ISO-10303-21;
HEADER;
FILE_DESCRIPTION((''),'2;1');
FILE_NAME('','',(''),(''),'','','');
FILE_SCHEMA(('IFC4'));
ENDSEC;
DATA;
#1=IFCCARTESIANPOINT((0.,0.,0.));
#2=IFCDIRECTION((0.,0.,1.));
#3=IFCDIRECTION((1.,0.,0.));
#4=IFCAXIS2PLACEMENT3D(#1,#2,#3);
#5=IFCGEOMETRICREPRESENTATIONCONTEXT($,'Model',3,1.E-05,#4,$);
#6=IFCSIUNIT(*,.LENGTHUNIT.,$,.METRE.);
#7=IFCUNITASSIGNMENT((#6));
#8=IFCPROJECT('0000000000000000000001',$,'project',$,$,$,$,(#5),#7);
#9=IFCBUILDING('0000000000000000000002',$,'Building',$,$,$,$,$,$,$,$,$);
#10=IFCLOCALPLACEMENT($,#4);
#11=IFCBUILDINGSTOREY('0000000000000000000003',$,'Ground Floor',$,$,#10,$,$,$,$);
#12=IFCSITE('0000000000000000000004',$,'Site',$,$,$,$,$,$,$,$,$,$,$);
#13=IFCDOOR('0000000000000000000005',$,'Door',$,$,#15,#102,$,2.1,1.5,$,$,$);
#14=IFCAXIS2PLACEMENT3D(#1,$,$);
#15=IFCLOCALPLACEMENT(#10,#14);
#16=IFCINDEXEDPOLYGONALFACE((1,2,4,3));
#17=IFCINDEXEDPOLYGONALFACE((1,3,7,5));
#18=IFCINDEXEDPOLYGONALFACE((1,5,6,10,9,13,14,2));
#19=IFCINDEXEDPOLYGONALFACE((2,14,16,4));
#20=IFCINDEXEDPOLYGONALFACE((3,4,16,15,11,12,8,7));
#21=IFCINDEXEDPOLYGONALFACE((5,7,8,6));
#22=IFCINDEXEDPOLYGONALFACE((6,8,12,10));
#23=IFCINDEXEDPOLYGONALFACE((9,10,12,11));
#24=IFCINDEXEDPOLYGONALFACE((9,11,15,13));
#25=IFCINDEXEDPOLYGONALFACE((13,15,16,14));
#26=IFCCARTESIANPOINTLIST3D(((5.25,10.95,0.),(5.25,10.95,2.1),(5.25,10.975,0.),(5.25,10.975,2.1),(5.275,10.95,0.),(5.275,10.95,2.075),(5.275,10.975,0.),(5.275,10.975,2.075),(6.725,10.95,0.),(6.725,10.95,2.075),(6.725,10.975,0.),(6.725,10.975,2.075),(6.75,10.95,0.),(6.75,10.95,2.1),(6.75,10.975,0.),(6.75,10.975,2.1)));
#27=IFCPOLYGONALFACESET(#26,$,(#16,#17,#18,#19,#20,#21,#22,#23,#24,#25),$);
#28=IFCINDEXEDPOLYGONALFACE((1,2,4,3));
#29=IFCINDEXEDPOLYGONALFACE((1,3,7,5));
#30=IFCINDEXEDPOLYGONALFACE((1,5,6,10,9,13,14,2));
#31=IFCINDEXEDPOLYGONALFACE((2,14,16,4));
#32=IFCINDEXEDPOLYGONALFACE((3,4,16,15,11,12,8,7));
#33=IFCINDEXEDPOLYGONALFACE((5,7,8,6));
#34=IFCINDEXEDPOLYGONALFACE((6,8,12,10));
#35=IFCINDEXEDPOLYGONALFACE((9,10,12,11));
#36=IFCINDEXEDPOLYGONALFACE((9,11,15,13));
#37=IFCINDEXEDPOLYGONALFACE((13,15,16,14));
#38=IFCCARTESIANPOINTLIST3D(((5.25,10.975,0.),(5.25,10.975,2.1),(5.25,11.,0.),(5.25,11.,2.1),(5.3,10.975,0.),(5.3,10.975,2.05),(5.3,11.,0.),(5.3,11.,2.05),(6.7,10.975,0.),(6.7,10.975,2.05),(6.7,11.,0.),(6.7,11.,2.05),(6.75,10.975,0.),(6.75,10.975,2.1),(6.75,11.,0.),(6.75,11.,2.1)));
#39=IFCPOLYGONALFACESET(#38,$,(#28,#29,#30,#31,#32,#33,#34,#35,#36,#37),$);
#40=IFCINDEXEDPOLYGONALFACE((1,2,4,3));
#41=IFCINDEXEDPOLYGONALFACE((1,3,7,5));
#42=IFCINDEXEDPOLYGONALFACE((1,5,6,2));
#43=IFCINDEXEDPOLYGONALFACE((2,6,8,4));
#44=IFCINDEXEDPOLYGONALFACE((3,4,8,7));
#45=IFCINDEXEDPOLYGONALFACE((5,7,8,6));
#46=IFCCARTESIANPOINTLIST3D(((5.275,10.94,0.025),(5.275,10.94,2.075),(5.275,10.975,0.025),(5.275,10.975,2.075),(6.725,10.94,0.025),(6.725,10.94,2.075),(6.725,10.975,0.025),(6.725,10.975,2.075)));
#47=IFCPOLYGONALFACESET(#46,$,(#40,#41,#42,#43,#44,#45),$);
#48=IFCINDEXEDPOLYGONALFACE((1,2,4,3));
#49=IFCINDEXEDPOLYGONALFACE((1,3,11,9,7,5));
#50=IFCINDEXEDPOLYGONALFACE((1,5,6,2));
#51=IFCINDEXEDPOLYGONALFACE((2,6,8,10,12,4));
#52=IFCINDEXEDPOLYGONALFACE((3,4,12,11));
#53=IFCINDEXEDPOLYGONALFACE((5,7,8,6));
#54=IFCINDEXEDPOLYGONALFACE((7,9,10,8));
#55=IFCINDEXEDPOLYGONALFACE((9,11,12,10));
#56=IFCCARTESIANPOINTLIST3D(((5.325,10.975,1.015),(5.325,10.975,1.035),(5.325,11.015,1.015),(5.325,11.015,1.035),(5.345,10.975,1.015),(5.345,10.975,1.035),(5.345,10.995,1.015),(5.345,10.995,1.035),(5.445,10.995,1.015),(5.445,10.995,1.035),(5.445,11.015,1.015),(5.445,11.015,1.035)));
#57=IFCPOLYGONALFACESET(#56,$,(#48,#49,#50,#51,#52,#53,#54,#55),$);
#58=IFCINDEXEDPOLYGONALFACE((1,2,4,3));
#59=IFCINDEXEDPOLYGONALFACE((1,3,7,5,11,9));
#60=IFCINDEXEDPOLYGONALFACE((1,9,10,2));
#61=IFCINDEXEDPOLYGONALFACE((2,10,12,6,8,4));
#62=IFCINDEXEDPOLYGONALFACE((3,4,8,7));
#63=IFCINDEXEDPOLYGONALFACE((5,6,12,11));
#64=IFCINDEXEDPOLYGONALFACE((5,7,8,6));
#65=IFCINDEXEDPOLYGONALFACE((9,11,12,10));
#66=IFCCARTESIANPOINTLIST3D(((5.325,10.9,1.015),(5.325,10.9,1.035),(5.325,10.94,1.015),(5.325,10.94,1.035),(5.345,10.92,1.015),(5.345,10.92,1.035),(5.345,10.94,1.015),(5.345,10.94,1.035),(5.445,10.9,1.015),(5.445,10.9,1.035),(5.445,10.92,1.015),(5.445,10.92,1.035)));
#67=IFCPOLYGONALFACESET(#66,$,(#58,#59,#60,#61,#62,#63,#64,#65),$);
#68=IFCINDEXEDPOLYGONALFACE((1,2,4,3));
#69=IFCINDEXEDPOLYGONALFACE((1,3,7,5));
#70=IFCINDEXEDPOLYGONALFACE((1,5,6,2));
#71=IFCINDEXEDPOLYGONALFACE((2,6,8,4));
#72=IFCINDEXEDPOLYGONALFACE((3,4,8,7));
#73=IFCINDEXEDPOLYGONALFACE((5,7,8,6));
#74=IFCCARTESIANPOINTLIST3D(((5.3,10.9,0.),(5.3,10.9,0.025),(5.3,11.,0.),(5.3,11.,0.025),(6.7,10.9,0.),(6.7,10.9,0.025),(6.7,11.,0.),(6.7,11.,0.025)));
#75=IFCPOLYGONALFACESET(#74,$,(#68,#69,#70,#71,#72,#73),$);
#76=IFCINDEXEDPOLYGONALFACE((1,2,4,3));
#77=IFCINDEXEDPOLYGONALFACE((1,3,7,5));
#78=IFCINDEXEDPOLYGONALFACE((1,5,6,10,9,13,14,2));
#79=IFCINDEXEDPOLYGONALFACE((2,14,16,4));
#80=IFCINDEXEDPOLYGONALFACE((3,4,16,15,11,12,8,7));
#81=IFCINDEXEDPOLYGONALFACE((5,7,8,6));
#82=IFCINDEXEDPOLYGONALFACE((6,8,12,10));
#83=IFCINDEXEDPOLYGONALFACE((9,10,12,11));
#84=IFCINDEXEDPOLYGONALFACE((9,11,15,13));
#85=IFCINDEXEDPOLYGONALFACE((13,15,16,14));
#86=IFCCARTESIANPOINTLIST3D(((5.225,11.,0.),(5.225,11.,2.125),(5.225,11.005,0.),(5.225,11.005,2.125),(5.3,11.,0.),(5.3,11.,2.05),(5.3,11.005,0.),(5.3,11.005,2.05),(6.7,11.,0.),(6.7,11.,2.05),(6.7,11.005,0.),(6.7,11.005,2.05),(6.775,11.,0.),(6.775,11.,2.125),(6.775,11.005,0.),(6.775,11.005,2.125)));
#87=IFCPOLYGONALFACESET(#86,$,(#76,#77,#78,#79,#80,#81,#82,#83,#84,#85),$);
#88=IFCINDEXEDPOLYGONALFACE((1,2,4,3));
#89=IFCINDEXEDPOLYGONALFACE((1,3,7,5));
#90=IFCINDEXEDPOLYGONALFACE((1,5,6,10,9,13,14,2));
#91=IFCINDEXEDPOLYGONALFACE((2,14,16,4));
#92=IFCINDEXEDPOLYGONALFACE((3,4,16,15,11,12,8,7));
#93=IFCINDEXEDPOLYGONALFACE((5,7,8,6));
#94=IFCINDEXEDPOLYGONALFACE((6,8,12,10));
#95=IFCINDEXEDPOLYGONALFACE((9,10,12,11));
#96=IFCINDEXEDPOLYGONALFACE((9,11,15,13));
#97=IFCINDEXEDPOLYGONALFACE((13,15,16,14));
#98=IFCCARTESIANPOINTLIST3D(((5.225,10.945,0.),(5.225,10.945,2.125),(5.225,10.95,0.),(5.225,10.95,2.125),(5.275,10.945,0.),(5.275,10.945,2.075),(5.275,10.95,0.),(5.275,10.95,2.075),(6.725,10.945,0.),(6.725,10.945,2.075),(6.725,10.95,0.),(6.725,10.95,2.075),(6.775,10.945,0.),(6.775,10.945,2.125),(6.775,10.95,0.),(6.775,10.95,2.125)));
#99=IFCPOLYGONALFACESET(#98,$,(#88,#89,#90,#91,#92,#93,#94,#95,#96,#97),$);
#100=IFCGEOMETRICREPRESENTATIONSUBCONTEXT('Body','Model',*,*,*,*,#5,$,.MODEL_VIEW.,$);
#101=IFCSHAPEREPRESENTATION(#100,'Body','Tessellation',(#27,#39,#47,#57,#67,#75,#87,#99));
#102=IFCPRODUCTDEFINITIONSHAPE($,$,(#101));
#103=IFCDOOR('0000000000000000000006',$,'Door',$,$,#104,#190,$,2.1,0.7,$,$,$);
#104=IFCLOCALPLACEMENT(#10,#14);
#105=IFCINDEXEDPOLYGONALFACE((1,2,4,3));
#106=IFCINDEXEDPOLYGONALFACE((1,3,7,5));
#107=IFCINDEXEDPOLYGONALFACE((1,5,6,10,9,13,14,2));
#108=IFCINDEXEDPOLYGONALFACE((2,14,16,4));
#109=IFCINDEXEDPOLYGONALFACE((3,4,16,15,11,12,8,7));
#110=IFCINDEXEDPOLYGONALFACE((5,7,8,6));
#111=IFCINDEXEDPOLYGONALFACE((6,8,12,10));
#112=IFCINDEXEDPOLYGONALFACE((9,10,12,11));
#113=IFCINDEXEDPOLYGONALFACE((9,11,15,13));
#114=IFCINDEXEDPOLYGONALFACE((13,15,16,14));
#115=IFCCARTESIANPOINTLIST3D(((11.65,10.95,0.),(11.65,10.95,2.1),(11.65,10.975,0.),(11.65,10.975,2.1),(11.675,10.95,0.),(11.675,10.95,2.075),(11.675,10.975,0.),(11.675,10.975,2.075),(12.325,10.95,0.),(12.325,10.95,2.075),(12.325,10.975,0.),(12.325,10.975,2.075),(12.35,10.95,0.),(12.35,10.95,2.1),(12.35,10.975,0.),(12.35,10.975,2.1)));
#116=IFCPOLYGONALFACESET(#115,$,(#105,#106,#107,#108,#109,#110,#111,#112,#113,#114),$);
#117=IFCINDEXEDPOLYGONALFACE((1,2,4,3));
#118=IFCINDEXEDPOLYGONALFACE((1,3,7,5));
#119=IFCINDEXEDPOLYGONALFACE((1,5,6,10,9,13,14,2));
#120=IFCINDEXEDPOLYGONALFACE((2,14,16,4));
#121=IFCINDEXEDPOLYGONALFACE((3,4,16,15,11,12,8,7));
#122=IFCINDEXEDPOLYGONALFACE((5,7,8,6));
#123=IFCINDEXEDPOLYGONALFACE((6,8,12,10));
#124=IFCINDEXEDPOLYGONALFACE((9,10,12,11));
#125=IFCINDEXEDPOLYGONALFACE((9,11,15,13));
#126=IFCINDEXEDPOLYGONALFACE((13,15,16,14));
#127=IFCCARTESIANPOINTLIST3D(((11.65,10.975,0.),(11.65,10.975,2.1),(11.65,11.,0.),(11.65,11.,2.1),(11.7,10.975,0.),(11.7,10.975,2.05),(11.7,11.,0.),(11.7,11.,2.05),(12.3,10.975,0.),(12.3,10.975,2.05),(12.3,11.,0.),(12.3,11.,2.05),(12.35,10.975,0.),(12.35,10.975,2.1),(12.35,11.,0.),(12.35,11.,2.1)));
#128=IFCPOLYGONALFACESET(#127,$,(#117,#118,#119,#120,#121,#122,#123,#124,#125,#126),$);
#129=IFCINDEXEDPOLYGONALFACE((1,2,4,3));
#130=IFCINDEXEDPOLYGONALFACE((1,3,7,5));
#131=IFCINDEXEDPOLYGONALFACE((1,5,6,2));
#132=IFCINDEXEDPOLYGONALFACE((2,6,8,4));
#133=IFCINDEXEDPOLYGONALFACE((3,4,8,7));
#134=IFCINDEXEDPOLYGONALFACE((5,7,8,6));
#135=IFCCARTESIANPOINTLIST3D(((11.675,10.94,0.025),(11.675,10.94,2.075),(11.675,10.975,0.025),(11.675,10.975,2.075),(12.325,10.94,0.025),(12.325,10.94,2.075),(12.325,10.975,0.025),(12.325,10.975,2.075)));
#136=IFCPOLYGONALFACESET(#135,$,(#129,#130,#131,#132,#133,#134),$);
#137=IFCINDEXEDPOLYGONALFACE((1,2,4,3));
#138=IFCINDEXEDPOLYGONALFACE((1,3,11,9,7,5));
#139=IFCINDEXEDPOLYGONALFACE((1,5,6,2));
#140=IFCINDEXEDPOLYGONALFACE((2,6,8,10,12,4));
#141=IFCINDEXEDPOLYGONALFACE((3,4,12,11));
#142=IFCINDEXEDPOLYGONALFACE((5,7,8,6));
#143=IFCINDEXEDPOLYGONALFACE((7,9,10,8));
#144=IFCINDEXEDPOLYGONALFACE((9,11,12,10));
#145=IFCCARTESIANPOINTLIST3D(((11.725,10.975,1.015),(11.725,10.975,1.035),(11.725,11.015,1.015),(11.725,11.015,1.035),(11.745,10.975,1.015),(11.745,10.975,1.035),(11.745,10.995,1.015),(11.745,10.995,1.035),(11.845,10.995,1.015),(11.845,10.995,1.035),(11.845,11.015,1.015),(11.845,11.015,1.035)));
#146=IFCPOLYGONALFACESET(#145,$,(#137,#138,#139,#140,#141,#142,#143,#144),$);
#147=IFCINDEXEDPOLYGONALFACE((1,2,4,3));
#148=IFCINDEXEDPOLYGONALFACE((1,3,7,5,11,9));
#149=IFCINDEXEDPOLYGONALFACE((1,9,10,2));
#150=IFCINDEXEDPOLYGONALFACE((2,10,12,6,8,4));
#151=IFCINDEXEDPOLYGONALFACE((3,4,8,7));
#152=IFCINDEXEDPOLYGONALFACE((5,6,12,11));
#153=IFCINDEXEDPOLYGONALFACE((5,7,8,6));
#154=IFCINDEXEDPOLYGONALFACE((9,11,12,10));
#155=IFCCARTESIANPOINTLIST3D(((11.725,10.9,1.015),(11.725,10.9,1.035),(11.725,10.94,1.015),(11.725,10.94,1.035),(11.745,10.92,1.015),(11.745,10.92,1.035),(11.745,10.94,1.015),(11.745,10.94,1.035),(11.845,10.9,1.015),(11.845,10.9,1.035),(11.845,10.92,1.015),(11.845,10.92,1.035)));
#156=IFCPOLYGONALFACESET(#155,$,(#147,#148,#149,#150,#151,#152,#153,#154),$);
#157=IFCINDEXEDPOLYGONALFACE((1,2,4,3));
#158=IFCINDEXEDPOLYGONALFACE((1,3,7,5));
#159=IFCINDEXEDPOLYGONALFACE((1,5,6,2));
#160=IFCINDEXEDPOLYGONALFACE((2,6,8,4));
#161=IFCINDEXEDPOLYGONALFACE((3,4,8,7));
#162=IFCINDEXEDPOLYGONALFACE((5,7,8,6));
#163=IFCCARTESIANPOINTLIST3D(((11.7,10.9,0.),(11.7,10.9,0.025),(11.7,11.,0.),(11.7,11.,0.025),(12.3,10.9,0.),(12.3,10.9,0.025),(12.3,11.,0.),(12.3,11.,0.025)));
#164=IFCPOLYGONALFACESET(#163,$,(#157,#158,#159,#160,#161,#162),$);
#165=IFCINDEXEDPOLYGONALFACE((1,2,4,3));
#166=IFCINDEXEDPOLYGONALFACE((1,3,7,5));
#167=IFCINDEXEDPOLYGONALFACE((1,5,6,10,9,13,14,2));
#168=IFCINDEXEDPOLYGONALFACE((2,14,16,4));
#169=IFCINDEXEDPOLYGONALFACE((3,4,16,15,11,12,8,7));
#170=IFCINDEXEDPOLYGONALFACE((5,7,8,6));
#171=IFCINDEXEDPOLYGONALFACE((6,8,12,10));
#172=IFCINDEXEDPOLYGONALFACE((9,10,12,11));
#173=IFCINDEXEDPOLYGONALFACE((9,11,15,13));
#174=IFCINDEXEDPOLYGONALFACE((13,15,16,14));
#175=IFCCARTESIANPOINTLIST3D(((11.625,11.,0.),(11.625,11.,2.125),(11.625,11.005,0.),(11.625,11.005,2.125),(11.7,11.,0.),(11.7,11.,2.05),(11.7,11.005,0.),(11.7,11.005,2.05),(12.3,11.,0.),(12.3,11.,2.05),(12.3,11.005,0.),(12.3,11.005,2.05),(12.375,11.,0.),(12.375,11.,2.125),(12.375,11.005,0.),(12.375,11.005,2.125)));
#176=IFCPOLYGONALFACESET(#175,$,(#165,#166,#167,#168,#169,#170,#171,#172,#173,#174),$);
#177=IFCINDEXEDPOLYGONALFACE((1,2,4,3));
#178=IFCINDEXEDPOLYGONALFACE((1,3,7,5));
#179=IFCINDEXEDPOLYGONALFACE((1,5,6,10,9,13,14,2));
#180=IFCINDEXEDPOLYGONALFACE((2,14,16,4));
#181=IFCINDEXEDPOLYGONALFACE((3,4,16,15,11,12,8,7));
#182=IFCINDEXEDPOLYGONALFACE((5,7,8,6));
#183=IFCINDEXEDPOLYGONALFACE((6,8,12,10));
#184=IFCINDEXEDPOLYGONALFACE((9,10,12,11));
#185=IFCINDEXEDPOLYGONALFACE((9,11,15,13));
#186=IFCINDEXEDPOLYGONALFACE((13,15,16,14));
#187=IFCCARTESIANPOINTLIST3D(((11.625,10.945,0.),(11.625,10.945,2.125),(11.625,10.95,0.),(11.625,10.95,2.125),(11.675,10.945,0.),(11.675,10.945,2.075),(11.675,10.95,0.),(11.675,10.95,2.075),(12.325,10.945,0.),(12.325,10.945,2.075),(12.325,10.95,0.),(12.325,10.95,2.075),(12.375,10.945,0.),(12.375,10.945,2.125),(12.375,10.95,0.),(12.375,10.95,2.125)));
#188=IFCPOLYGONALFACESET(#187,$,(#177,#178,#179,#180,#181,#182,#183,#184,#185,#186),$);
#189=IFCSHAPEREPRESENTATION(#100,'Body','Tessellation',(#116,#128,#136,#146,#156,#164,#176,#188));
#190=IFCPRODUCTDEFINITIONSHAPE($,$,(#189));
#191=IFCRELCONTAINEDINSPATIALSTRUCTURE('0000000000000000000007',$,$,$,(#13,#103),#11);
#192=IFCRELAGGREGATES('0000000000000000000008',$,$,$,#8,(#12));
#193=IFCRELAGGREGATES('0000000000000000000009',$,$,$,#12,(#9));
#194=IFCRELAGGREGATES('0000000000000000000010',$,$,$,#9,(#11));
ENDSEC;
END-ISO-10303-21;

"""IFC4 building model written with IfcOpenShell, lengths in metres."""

from ifc_helpers import new_model, si_unit, frame, origin_with_axes, place, context, subcontext, project, spatial, line, indexed_curve, outline, extrude, element, save


model = new_model("IFC4")

# Units and contexts
model_context = context("Model", 3, precision=1e-05, world=origin_with_axes())
body_context = subcontext(model_context, "Body", "Model", "MODEL_VIEW")
ifc_project = project(units=[si_unit("LENGTHUNIT", "METRE")], contexts=[model_context])

# Site, building, storey
site = spatial("IfcSite", under=ifc_project, Name="Site")
building = spatial("IfcBuilding", under=site, Name="Building")
storey_placement = place(None, origin_with_axes())
storey = spatial("IfcBuildingStorey", under=building, at=storey_placement, Name="Ground Floor")

# Doors
door_1_placement = place(storey_placement, frame((6.75, 11.0, 0.0), z_axis=(0.0, 0.0, 1.0), x_axis=(-1.0, 0.0, 0.0)))
element("IfcDoor", 1, at=door_1_placement, inside=storey, Name="Door", OverallHeight=2.1, OverallWidth=1.5, context=body_context, shape_type="SweptSolid", body=[
    extrude(outline(indexed_curve([(0.0, 0.0), (0.0, 2.1), (1.5, 2.1), (1.5, 0.0), (1.475, 0.0), (1.475, 2.075), (0.025, 2.075), (0.025, 0.0)], segments=[line(1, 2, 3, 4, 5, 6, 7, 8, 1)])), frame((0.0, 0.025, 0.0), z_axis=(0.0, -1.0, 0.0), x_axis=(1.0, 0.0, 0.0)), (0.0, 0.0, -1.0), 0.025),
    extrude(outline(indexed_curve([(0.0, 0.0), (0.0, 2.1), (1.5, 2.1), (1.5, 0.0), (1.45, 0.0), (1.45, 2.05), (0.05, 2.05), (0.05, 0.0)], segments=[line(1, 2, 3, 4, 5, 6, 7, 8, 1)])), frame((0.0, 0.0, 0.0), z_axis=(0.0, -1.0, 0.0), x_axis=(1.0, 0.0, 0.0)), (0.0, 0.0, -1.0), 0.025),
    extrude(outline(indexed_curve([(0.0, 0.0), (1.45, 0.0), (1.45, 0.035), (0.0, 0.035)], segments=[line(1, 2, 3, 4, 1)])), frame((0.025, 0.025, 0.025), z_axis=(0.0, 0.0, 1.0), x_axis=(1.0, 0.0, 0.0)), (0.0, 0.0, 1.0), 2.05),
    extrude(outline(indexed_curve([(0.0, 0.0), (0.0, -0.04), (-0.12, -0.04), (-0.12, -0.02), (-0.02, -0.02), (-0.02, 0.0)], segments=[line(1, 2, 3, 4, 5, 6, 1)])), frame((1.425, 0.025, 1.015), z_axis=(0.0, 0.0, 1.0), x_axis=(1.0, 0.0, 0.0)), (0.0, 0.0, 1.0), 0.02),
    extrude(outline(indexed_curve([(0.0, 0.0), (0.0, 0.04), (-0.12, 0.04), (-0.12, 0.02), (-0.02, 0.02), (-0.02, 0.0)], segments=[line(1, 2, 3, 4, 5, 6, 1)])), frame((1.425, 0.06, 1.015), z_axis=(0.0, 0.0, 1.0), x_axis=(1.0, 0.0, 0.0)), (0.0, 0.0, 1.0), 0.02),
    extrude(outline(indexed_curve([(0.0, 0.0), (1.4, 0.0), (1.4, 0.1), (0.0, 0.1)], segments=[line(1, 2, 3, 4, 1)])), frame((0.05, 0.0, 0.0), z_axis=(0.0, 0.0, 1.0), x_axis=(1.0, 0.0, 0.0)), (0.0, 0.0, 1.0), 0.025),
    extrude(outline(indexed_curve([(0.0, 0.0), (0.0, 2.125), (1.55, 2.125), (1.55, 0.0), (1.475, 0.0), (1.475, 2.05), (0.075, 2.05), (0.075, 0.0)], segments=[line(1, 2, 3, 4, 5, 6, 7, 8, 1)])), frame((-0.025, -0.005, 0.0), z_axis=(0.0, -1.0, 0.0), x_axis=(1.0, 0.0, 0.0)), (0.0, 0.0, -1.0), 0.005),
    extrude(outline(indexed_curve([(0.0, 0.0), (0.0, 2.125), (1.55, 2.125), (1.55, 0.0), (1.5, 0.0), (1.5, 2.075), (0.05, 2.075), (0.05, 0.0)], segments=[line(1, 2, 3, 4, 5, 6, 7, 8, 1)])), frame((-0.025, 0.05, 0.0), z_axis=(0.0, -1.0, 0.0), x_axis=(1.0, 0.0, 0.0)), (0.0, 0.0, -1.0), 0.005),
])
door_2_placement = place(storey_placement, frame((12.35, 11.0, 0.0), z_axis=(0.0, 0.0, 1.0), x_axis=(-1.0, 0.0, 0.0)))
element("IfcDoor", 2, at=door_2_placement, inside=storey, Name="Door", OverallHeight=2.1, OverallWidth=0.7, context=body_context, shape_type="SweptSolid", body=[
    extrude(outline(indexed_curve([(0.0, 0.0), (0.0, 2.1), (0.7, 2.1), (0.7, 0.0), (0.675, 0.0), (0.675, 2.075), (0.025, 2.075), (0.025, 0.0)], segments=[line(1, 2, 3, 4, 5, 6, 7, 8, 1)])), frame((0.0, 0.025, 0.0), z_axis=(0.0, -1.0, 0.0), x_axis=(1.0, 0.0, 0.0)), (0.0, 0.0, -1.0), 0.025),
    extrude(outline(indexed_curve([(0.0, 0.0), (0.0, 2.1), (0.7, 2.1), (0.7, 0.0), (0.65, 0.0), (0.65, 2.05), (0.05, 2.05), (0.05, 0.0)], segments=[line(1, 2, 3, 4, 5, 6, 7, 8, 1)])), frame((0.0, 0.0, 0.0), z_axis=(0.0, -1.0, 0.0), x_axis=(1.0, 0.0, 0.0)), (0.0, 0.0, -1.0), 0.025),
    extrude(outline(indexed_curve([(0.0, 0.0), (0.65, 0.0), (0.65, 0.035), (0.0, 0.035)], segments=[line(1, 2, 3, 4, 1)])), frame((0.025, 0.025, 0.025), z_axis=(0.0, 0.0, 1.0), x_axis=(1.0, 0.0, 0.0)), (0.0, 0.0, 1.0), 2.05),
    extrude(outline(indexed_curve([(0.0, 0.0), (0.0, -0.04), (-0.12, -0.04), (-0.12, -0.02), (-0.02, -0.02), (-0.02, 0.0)], segments=[line(1, 2, 3, 4, 5, 6, 1)])), frame((0.625, 0.025, 1.015), z_axis=(0.0, 0.0, 1.0), x_axis=(1.0, 0.0, 0.0)), (0.0, 0.0, 1.0), 0.02),
    extrude(outline(indexed_curve([(0.0, 0.0), (0.0, 0.04), (-0.12, 0.04), (-0.12, 0.02), (-0.02, 0.02), (-0.02, 0.0)], segments=[line(1, 2, 3, 4, 5, 6, 1)])), frame((0.625, 0.06, 1.015), z_axis=(0.0, 0.0, 1.0), x_axis=(1.0, 0.0, 0.0)), (0.0, 0.0, 1.0), 0.02),
    extrude(outline(indexed_curve([(0.0, 0.0), (0.6, 0.0), (0.6, 0.1), (0.0, 0.1)], segments=[line(1, 2, 3, 4, 1)])), frame((0.05, 0.0, 0.0), z_axis=(0.0, 0.0, 1.0), x_axis=(1.0, 0.0, 0.0)), (0.0, 0.0, 1.0), 0.025),
    extrude(outline(indexed_curve([(0.0, 0.0), (0.0, 2.125), (0.75, 2.125), (0.75, 0.0), (0.675, 0.0), (0.675, 2.05), (0.075, 2.05), (0.075, 0.0)], segments=[line(1, 2, 3, 4, 5, 6, 7, 8, 1)])), frame((-0.025, -0.005, 0.0), z_axis=(0.0, -1.0, 0.0), x_axis=(1.0, 0.0, 0.0)), (0.0, 0.0, -1.0), 0.005),
    extrude(outline(indexed_curve([(0.0, 0.0), (0.0, 2.125), (0.75, 2.125), (0.75, 0.0), (0.7, 0.0), (0.7, 2.075), (0.05, 2.075), (0.05, 0.0)], segments=[line(1, 2, 3, 4, 5, 6, 7, 8, 1)])), frame((-0.025, 0.05, 0.0), z_axis=(0.0, -1.0, 0.0), x_axis=(1.0, 0.0, 0.0)), (0.0, 0.0, -1.0), 0.005),
])

save(model, "model.ifc")
